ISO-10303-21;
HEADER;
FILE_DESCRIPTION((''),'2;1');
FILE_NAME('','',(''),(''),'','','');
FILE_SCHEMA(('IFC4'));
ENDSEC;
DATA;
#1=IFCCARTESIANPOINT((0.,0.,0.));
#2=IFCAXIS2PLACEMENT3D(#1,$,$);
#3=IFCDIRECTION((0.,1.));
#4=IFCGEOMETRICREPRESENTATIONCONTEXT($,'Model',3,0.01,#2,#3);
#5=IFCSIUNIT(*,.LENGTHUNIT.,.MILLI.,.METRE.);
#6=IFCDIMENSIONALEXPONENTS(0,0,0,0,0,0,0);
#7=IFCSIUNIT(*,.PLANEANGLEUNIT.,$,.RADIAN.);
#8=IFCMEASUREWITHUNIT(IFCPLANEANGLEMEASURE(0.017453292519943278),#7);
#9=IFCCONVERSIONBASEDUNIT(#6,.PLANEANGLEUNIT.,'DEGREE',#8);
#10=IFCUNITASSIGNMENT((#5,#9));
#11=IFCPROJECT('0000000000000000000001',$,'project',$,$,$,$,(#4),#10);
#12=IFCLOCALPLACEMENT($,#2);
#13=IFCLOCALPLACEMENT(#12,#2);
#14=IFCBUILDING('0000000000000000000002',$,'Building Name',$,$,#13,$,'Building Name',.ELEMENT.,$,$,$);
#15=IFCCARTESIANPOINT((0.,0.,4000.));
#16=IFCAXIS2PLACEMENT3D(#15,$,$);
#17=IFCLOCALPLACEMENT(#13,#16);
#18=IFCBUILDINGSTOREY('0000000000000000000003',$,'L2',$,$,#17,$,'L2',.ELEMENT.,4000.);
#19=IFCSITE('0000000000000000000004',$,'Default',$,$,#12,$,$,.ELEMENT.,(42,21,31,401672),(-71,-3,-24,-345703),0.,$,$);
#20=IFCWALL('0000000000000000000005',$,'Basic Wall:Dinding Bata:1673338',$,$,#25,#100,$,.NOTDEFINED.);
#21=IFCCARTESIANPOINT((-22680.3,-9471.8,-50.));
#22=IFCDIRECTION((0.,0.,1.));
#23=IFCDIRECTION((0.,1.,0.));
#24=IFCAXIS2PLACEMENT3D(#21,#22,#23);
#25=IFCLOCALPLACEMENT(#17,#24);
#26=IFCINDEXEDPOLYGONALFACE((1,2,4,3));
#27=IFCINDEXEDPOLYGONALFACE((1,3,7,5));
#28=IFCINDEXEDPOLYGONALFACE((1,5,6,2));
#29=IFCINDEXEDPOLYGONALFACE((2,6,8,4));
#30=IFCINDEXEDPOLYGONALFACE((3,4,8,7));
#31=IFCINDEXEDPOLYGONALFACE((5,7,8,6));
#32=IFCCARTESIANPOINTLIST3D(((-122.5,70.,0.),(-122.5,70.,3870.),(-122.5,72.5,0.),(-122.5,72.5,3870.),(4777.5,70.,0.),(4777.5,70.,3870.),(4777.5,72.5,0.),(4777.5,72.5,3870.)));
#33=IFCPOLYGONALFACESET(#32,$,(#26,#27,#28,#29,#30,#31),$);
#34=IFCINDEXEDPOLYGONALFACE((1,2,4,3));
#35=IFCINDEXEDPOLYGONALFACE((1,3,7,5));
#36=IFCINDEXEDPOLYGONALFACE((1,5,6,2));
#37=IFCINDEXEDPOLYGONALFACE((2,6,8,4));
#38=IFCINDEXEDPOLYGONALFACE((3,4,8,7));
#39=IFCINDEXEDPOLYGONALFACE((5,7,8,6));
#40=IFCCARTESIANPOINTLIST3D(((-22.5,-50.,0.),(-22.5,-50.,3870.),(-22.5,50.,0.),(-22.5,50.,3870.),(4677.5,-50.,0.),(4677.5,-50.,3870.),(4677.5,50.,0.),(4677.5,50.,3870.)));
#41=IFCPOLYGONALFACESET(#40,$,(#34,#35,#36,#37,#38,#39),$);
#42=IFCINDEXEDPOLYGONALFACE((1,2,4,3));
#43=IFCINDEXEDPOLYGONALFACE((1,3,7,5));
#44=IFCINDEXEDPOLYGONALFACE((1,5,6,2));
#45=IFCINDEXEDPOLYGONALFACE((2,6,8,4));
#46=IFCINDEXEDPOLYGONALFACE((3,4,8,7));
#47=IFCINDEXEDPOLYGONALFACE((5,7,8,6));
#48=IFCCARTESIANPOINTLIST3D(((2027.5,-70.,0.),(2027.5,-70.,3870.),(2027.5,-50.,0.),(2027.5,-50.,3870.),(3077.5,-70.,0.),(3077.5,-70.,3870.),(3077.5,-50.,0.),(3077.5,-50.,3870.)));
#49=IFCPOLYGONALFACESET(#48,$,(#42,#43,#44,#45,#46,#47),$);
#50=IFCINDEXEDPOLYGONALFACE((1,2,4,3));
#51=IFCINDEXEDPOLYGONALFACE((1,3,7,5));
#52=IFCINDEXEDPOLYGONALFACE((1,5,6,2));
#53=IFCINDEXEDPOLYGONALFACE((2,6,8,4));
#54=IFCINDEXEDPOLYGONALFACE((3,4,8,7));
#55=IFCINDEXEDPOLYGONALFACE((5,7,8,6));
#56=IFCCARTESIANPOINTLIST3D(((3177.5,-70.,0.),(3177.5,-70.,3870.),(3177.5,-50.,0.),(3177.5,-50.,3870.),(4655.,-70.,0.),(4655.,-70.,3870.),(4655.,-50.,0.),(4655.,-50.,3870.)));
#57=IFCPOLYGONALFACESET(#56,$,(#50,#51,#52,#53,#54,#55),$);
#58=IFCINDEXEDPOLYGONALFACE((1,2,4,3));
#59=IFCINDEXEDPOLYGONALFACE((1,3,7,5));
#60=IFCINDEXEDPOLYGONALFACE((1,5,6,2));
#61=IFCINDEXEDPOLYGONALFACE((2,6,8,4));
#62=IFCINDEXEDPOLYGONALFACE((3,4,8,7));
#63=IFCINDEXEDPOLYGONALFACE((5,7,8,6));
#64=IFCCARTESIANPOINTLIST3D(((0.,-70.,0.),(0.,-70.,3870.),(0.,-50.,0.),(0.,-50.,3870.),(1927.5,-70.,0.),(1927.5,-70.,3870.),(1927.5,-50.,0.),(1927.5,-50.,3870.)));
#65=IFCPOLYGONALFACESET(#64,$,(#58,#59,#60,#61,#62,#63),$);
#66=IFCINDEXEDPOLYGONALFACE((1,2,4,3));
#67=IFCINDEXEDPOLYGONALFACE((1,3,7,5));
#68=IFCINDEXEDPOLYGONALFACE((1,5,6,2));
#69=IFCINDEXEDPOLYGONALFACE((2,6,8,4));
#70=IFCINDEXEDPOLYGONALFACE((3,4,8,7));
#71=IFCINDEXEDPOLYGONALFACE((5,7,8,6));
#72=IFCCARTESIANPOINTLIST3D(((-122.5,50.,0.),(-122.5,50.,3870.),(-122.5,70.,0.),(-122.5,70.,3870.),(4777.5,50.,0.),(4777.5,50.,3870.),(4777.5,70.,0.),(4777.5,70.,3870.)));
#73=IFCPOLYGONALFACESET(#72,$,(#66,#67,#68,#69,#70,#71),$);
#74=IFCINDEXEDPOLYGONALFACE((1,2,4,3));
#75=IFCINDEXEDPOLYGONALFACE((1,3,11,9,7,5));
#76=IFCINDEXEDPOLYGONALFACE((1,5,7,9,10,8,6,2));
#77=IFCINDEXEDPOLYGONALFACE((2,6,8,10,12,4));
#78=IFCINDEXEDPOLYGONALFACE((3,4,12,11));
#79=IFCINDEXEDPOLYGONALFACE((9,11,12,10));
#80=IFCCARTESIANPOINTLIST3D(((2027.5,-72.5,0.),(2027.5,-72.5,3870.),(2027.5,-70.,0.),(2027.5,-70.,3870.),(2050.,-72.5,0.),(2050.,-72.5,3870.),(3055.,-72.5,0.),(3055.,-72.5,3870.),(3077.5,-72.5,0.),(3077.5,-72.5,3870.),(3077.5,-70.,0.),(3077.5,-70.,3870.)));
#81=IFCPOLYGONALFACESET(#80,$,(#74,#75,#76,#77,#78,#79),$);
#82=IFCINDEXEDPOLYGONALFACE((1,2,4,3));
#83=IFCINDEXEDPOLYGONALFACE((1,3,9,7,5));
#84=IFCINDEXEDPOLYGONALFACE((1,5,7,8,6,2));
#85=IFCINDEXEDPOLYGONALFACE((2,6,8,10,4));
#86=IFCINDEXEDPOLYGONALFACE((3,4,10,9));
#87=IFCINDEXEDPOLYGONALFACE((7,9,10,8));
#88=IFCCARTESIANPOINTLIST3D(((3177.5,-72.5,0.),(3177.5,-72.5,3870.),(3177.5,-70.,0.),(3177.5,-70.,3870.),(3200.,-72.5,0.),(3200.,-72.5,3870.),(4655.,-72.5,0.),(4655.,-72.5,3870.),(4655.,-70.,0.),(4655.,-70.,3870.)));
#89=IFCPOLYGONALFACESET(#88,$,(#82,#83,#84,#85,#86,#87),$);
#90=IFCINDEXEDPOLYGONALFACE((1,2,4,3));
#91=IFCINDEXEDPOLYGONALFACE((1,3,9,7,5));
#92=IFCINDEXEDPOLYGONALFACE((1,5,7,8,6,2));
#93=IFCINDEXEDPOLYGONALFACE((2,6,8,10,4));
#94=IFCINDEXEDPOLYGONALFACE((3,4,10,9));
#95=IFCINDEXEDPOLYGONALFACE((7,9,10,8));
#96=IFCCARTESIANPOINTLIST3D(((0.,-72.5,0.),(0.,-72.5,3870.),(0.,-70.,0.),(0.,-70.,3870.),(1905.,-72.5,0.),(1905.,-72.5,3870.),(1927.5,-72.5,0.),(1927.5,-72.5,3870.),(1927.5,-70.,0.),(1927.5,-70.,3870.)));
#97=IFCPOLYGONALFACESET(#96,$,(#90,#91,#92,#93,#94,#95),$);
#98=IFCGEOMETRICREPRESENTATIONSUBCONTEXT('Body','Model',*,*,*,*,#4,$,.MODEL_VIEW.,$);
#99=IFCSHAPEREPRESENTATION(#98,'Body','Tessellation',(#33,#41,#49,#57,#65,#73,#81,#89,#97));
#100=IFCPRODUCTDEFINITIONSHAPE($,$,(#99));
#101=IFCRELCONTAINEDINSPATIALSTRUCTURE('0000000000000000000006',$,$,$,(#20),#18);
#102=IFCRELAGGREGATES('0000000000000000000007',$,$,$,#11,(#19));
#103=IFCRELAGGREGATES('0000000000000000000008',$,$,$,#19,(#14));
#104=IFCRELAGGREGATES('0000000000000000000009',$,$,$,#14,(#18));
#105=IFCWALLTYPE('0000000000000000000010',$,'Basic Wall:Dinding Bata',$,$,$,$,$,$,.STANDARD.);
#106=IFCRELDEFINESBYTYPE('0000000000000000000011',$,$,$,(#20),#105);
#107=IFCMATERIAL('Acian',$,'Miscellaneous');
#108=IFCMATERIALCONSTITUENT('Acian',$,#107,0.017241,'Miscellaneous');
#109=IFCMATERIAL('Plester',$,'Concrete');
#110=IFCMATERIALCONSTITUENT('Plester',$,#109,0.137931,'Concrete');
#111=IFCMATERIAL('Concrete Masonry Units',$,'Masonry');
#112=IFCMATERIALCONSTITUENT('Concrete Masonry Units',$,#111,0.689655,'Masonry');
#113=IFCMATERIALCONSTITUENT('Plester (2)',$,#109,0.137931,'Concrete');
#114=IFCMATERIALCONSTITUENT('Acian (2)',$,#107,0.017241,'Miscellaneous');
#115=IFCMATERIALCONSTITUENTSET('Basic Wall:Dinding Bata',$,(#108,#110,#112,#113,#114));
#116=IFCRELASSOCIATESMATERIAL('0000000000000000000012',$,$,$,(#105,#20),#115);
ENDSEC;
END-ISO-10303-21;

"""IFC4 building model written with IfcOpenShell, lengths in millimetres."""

from ifc_helpers import new_model, entity, si_unit, converted_unit, direction, frame, origin, place, context, subcontext, project, spatial, indexed_curve, outline, extrude, material, constituent, constituent_set, type_object, element, save


model = new_model("IFC4")

# Units and contexts
model_context = context("Model", 3, precision=0.01, world=origin(), true_north=direction((0.0, 1.0)))
body_context = subcontext(model_context, "Body", "Model", "MODEL_VIEW")
ifc_project = project(units=[si_unit("LENGTHUNIT", "METRE", prefix="MILLI"), converted_unit("PLANEANGLEUNIT", "DEGREE", entity("IfcPlaneAngleMeasure", 0.017453292519943278), si_unit("PLANEANGLEUNIT", "RADIAN"), dimensions=[0, 0, 0, 0, 0, 0, 0])], contexts=[model_context])

# Site, building, storey
site_placement = place(None, origin())
site = spatial("IfcSite", under=ifc_project, at=site_placement, Name="Default", CompositionType="ELEMENT", RefLatitude=(42, 21, 31, 401672), RefLongitude=(-71, -3, -24, -345703), RefElevation=0.0)
building_placement = place(site_placement, origin())
building = spatial("IfcBuilding", under=site, at=building_placement, Name="Building Name", LongName="Building Name", CompositionType="ELEMENT")
storey_placement = place(building_placement, frame((0.0, 0.0, 4000.0)))
storey = spatial("IfcBuildingStorey", under=building, at=storey_placement, Name="L2", LongName="L2", CompositionType="ELEMENT", Elevation=4000.0)

# Wall
ifc_material_1 = material(Name="Acian", Category="Miscellaneous")
ifc_constituent_1 = constituent(ifc_material_1, Name="Acian", Category="Miscellaneous", fraction=0.017241)
ifc_material_2 = material(Name="Plester", Category="Concrete")
ifc_constituent_2 = constituent(ifc_material_2, Name="Plester", Category="Concrete", fraction=0.137931)
ifc_material_3 = material(Name="Concrete Masonry Units", Category="Masonry")
ifc_constituent_3 = constituent(ifc_material_3, Name="Concrete Masonry Units", Category="Masonry", fraction=0.689655)
ifc_constituent_4 = constituent(ifc_material_2, Name="Plester (2)", Category="Concrete", fraction=0.137931)
ifc_constituent_5 = constituent(ifc_material_1, Name="Acian (2)", Category="Miscellaneous", fraction=0.017241)
ifc_constituent_set = constituent_set(constituents=[ifc_constituent_1, ifc_constituent_2, ifc_constituent_3, ifc_constituent_4, ifc_constituent_5], Name="Basic Wall:Dinding Bata")
wall_type = type_object("IfcWallType", Name="Basic Wall:Dinding Bata", PredefinedType="STANDARD", material=ifc_constituent_set)
wall_1_placement = place(storey_placement, frame((-22680.3, -9471.8, -50.0), z_axis=(0.0, 0.0, 1.0), x_axis=(0.0, 1.0, 0.0)))
element("IfcWall", 1, at=wall_1_placement, inside=storey, type_object=wall_type, material=ifc_constituent_set, Name="Basic Wall:Dinding Bata:1673338", PredefinedType="NOTDEFINED", context=body_context, shape_type="SweptSolid", body=[
    extrude(outline(indexed_curve([(-1.3, -2450.0), (1.2, -2450.0), (1.3, 2450.0), (-1.2, 2450.0), (-1.3, -2450.0)], self_intersect=False)), frame((2327.5, 71.3, 0.0), z_axis=(0.0, 0.0, 1.0), x_axis=(0.0, -1.0, 0.0)), (0.0, 0.0, 1.0), 3870.0),
    extrude(outline(indexed_curve([(-2350.0, -50.0), (2350.0, -50.0), (2350.0, 50.0), (-2350.0, 50.0), (-2350.0, -50.0)], self_intersect=False)), frame((2327.5, 0.0, 0.0)), (0.0, 0.0, 1.0), 3870.0),
    extrude(outline(indexed_curve([(-525.0, -10.0), (525.0, -10.0), (525.0, 10.0), (-525.0, 10.0), (-525.0, -10.0)], self_intersect=False)), frame((2552.5, -60.0, 0.0)), (0.0, 0.0, 1.0), 3870.0),
    extrude(outline(indexed_curve([(-738.7, -10.0), (738.7, -10.0), (738.7, 10.0), (-738.7, 10.0), (-738.7, -10.0)], self_intersect=False)), frame((3916.2, -60.0, 0.0), z_axis=(0.0, 0.0, 1.0), x_axis=(-1.0, 0.0, 0.0)), (0.0, 0.0, 1.0), 3870.0),
    extrude(outline(indexed_curve([(-963.8, -10.0), (963.8, -10.0), (963.8, 10.0), (-963.8, 10.0), (-963.8, -10.0)], self_intersect=False)), frame((963.8, -60.0, 0.0)), (0.0, 0.0, 1.0), 3870.0),
    extrude(outline(indexed_curve([(-2450.0, -10.0), (2450.0, -10.0), (2450.0, 10.0), (-2450.0, 10.0), (-2450.0, -10.0)], self_intersect=False)), frame((2327.5, 60.0, 0.0)), (0.0, 0.0, 1.0), 3870.0),
    extrude(outline(indexed_curve([(502.5, -0.8), (525.0, -0.8), (525.0, 1.7), (-525.0, 1.7), (-525.0, -0.8), (-502.5, -0.8), (502.5, -0.8)], self_intersect=False)), frame((2552.5, -71.7, 0.0)), (0.0, 0.0, 1.0), 3870.0),
    extrude(outline(indexed_curve([(-1.0, -882.0), (1.5, -882.0), (1.5, 595.5), (-1.0, 595.5), (-1.0, 573.0), (-1.0, -882.0)], self_intersect=False)), frame((3773.0, -71.5, 0.0), z_axis=(0.0, 0.0, 1.0), x_axis=(0.0, 1.0, 0.0)), (0.0, 0.0, 1.0), 3870.0),
    extrude(outline(indexed_curve([(753.0, -1.0), (775.5, -1.0), (775.5, 1.5), (-1152.0, 1.5), (-1152.0, -1.0), (753.0, -1.0)], self_intersect=False)), frame((1152.0, -71.5, 0.0)), (0.0, 0.0, 1.0), 3870.0),
])

save(model, "model.ifc")
